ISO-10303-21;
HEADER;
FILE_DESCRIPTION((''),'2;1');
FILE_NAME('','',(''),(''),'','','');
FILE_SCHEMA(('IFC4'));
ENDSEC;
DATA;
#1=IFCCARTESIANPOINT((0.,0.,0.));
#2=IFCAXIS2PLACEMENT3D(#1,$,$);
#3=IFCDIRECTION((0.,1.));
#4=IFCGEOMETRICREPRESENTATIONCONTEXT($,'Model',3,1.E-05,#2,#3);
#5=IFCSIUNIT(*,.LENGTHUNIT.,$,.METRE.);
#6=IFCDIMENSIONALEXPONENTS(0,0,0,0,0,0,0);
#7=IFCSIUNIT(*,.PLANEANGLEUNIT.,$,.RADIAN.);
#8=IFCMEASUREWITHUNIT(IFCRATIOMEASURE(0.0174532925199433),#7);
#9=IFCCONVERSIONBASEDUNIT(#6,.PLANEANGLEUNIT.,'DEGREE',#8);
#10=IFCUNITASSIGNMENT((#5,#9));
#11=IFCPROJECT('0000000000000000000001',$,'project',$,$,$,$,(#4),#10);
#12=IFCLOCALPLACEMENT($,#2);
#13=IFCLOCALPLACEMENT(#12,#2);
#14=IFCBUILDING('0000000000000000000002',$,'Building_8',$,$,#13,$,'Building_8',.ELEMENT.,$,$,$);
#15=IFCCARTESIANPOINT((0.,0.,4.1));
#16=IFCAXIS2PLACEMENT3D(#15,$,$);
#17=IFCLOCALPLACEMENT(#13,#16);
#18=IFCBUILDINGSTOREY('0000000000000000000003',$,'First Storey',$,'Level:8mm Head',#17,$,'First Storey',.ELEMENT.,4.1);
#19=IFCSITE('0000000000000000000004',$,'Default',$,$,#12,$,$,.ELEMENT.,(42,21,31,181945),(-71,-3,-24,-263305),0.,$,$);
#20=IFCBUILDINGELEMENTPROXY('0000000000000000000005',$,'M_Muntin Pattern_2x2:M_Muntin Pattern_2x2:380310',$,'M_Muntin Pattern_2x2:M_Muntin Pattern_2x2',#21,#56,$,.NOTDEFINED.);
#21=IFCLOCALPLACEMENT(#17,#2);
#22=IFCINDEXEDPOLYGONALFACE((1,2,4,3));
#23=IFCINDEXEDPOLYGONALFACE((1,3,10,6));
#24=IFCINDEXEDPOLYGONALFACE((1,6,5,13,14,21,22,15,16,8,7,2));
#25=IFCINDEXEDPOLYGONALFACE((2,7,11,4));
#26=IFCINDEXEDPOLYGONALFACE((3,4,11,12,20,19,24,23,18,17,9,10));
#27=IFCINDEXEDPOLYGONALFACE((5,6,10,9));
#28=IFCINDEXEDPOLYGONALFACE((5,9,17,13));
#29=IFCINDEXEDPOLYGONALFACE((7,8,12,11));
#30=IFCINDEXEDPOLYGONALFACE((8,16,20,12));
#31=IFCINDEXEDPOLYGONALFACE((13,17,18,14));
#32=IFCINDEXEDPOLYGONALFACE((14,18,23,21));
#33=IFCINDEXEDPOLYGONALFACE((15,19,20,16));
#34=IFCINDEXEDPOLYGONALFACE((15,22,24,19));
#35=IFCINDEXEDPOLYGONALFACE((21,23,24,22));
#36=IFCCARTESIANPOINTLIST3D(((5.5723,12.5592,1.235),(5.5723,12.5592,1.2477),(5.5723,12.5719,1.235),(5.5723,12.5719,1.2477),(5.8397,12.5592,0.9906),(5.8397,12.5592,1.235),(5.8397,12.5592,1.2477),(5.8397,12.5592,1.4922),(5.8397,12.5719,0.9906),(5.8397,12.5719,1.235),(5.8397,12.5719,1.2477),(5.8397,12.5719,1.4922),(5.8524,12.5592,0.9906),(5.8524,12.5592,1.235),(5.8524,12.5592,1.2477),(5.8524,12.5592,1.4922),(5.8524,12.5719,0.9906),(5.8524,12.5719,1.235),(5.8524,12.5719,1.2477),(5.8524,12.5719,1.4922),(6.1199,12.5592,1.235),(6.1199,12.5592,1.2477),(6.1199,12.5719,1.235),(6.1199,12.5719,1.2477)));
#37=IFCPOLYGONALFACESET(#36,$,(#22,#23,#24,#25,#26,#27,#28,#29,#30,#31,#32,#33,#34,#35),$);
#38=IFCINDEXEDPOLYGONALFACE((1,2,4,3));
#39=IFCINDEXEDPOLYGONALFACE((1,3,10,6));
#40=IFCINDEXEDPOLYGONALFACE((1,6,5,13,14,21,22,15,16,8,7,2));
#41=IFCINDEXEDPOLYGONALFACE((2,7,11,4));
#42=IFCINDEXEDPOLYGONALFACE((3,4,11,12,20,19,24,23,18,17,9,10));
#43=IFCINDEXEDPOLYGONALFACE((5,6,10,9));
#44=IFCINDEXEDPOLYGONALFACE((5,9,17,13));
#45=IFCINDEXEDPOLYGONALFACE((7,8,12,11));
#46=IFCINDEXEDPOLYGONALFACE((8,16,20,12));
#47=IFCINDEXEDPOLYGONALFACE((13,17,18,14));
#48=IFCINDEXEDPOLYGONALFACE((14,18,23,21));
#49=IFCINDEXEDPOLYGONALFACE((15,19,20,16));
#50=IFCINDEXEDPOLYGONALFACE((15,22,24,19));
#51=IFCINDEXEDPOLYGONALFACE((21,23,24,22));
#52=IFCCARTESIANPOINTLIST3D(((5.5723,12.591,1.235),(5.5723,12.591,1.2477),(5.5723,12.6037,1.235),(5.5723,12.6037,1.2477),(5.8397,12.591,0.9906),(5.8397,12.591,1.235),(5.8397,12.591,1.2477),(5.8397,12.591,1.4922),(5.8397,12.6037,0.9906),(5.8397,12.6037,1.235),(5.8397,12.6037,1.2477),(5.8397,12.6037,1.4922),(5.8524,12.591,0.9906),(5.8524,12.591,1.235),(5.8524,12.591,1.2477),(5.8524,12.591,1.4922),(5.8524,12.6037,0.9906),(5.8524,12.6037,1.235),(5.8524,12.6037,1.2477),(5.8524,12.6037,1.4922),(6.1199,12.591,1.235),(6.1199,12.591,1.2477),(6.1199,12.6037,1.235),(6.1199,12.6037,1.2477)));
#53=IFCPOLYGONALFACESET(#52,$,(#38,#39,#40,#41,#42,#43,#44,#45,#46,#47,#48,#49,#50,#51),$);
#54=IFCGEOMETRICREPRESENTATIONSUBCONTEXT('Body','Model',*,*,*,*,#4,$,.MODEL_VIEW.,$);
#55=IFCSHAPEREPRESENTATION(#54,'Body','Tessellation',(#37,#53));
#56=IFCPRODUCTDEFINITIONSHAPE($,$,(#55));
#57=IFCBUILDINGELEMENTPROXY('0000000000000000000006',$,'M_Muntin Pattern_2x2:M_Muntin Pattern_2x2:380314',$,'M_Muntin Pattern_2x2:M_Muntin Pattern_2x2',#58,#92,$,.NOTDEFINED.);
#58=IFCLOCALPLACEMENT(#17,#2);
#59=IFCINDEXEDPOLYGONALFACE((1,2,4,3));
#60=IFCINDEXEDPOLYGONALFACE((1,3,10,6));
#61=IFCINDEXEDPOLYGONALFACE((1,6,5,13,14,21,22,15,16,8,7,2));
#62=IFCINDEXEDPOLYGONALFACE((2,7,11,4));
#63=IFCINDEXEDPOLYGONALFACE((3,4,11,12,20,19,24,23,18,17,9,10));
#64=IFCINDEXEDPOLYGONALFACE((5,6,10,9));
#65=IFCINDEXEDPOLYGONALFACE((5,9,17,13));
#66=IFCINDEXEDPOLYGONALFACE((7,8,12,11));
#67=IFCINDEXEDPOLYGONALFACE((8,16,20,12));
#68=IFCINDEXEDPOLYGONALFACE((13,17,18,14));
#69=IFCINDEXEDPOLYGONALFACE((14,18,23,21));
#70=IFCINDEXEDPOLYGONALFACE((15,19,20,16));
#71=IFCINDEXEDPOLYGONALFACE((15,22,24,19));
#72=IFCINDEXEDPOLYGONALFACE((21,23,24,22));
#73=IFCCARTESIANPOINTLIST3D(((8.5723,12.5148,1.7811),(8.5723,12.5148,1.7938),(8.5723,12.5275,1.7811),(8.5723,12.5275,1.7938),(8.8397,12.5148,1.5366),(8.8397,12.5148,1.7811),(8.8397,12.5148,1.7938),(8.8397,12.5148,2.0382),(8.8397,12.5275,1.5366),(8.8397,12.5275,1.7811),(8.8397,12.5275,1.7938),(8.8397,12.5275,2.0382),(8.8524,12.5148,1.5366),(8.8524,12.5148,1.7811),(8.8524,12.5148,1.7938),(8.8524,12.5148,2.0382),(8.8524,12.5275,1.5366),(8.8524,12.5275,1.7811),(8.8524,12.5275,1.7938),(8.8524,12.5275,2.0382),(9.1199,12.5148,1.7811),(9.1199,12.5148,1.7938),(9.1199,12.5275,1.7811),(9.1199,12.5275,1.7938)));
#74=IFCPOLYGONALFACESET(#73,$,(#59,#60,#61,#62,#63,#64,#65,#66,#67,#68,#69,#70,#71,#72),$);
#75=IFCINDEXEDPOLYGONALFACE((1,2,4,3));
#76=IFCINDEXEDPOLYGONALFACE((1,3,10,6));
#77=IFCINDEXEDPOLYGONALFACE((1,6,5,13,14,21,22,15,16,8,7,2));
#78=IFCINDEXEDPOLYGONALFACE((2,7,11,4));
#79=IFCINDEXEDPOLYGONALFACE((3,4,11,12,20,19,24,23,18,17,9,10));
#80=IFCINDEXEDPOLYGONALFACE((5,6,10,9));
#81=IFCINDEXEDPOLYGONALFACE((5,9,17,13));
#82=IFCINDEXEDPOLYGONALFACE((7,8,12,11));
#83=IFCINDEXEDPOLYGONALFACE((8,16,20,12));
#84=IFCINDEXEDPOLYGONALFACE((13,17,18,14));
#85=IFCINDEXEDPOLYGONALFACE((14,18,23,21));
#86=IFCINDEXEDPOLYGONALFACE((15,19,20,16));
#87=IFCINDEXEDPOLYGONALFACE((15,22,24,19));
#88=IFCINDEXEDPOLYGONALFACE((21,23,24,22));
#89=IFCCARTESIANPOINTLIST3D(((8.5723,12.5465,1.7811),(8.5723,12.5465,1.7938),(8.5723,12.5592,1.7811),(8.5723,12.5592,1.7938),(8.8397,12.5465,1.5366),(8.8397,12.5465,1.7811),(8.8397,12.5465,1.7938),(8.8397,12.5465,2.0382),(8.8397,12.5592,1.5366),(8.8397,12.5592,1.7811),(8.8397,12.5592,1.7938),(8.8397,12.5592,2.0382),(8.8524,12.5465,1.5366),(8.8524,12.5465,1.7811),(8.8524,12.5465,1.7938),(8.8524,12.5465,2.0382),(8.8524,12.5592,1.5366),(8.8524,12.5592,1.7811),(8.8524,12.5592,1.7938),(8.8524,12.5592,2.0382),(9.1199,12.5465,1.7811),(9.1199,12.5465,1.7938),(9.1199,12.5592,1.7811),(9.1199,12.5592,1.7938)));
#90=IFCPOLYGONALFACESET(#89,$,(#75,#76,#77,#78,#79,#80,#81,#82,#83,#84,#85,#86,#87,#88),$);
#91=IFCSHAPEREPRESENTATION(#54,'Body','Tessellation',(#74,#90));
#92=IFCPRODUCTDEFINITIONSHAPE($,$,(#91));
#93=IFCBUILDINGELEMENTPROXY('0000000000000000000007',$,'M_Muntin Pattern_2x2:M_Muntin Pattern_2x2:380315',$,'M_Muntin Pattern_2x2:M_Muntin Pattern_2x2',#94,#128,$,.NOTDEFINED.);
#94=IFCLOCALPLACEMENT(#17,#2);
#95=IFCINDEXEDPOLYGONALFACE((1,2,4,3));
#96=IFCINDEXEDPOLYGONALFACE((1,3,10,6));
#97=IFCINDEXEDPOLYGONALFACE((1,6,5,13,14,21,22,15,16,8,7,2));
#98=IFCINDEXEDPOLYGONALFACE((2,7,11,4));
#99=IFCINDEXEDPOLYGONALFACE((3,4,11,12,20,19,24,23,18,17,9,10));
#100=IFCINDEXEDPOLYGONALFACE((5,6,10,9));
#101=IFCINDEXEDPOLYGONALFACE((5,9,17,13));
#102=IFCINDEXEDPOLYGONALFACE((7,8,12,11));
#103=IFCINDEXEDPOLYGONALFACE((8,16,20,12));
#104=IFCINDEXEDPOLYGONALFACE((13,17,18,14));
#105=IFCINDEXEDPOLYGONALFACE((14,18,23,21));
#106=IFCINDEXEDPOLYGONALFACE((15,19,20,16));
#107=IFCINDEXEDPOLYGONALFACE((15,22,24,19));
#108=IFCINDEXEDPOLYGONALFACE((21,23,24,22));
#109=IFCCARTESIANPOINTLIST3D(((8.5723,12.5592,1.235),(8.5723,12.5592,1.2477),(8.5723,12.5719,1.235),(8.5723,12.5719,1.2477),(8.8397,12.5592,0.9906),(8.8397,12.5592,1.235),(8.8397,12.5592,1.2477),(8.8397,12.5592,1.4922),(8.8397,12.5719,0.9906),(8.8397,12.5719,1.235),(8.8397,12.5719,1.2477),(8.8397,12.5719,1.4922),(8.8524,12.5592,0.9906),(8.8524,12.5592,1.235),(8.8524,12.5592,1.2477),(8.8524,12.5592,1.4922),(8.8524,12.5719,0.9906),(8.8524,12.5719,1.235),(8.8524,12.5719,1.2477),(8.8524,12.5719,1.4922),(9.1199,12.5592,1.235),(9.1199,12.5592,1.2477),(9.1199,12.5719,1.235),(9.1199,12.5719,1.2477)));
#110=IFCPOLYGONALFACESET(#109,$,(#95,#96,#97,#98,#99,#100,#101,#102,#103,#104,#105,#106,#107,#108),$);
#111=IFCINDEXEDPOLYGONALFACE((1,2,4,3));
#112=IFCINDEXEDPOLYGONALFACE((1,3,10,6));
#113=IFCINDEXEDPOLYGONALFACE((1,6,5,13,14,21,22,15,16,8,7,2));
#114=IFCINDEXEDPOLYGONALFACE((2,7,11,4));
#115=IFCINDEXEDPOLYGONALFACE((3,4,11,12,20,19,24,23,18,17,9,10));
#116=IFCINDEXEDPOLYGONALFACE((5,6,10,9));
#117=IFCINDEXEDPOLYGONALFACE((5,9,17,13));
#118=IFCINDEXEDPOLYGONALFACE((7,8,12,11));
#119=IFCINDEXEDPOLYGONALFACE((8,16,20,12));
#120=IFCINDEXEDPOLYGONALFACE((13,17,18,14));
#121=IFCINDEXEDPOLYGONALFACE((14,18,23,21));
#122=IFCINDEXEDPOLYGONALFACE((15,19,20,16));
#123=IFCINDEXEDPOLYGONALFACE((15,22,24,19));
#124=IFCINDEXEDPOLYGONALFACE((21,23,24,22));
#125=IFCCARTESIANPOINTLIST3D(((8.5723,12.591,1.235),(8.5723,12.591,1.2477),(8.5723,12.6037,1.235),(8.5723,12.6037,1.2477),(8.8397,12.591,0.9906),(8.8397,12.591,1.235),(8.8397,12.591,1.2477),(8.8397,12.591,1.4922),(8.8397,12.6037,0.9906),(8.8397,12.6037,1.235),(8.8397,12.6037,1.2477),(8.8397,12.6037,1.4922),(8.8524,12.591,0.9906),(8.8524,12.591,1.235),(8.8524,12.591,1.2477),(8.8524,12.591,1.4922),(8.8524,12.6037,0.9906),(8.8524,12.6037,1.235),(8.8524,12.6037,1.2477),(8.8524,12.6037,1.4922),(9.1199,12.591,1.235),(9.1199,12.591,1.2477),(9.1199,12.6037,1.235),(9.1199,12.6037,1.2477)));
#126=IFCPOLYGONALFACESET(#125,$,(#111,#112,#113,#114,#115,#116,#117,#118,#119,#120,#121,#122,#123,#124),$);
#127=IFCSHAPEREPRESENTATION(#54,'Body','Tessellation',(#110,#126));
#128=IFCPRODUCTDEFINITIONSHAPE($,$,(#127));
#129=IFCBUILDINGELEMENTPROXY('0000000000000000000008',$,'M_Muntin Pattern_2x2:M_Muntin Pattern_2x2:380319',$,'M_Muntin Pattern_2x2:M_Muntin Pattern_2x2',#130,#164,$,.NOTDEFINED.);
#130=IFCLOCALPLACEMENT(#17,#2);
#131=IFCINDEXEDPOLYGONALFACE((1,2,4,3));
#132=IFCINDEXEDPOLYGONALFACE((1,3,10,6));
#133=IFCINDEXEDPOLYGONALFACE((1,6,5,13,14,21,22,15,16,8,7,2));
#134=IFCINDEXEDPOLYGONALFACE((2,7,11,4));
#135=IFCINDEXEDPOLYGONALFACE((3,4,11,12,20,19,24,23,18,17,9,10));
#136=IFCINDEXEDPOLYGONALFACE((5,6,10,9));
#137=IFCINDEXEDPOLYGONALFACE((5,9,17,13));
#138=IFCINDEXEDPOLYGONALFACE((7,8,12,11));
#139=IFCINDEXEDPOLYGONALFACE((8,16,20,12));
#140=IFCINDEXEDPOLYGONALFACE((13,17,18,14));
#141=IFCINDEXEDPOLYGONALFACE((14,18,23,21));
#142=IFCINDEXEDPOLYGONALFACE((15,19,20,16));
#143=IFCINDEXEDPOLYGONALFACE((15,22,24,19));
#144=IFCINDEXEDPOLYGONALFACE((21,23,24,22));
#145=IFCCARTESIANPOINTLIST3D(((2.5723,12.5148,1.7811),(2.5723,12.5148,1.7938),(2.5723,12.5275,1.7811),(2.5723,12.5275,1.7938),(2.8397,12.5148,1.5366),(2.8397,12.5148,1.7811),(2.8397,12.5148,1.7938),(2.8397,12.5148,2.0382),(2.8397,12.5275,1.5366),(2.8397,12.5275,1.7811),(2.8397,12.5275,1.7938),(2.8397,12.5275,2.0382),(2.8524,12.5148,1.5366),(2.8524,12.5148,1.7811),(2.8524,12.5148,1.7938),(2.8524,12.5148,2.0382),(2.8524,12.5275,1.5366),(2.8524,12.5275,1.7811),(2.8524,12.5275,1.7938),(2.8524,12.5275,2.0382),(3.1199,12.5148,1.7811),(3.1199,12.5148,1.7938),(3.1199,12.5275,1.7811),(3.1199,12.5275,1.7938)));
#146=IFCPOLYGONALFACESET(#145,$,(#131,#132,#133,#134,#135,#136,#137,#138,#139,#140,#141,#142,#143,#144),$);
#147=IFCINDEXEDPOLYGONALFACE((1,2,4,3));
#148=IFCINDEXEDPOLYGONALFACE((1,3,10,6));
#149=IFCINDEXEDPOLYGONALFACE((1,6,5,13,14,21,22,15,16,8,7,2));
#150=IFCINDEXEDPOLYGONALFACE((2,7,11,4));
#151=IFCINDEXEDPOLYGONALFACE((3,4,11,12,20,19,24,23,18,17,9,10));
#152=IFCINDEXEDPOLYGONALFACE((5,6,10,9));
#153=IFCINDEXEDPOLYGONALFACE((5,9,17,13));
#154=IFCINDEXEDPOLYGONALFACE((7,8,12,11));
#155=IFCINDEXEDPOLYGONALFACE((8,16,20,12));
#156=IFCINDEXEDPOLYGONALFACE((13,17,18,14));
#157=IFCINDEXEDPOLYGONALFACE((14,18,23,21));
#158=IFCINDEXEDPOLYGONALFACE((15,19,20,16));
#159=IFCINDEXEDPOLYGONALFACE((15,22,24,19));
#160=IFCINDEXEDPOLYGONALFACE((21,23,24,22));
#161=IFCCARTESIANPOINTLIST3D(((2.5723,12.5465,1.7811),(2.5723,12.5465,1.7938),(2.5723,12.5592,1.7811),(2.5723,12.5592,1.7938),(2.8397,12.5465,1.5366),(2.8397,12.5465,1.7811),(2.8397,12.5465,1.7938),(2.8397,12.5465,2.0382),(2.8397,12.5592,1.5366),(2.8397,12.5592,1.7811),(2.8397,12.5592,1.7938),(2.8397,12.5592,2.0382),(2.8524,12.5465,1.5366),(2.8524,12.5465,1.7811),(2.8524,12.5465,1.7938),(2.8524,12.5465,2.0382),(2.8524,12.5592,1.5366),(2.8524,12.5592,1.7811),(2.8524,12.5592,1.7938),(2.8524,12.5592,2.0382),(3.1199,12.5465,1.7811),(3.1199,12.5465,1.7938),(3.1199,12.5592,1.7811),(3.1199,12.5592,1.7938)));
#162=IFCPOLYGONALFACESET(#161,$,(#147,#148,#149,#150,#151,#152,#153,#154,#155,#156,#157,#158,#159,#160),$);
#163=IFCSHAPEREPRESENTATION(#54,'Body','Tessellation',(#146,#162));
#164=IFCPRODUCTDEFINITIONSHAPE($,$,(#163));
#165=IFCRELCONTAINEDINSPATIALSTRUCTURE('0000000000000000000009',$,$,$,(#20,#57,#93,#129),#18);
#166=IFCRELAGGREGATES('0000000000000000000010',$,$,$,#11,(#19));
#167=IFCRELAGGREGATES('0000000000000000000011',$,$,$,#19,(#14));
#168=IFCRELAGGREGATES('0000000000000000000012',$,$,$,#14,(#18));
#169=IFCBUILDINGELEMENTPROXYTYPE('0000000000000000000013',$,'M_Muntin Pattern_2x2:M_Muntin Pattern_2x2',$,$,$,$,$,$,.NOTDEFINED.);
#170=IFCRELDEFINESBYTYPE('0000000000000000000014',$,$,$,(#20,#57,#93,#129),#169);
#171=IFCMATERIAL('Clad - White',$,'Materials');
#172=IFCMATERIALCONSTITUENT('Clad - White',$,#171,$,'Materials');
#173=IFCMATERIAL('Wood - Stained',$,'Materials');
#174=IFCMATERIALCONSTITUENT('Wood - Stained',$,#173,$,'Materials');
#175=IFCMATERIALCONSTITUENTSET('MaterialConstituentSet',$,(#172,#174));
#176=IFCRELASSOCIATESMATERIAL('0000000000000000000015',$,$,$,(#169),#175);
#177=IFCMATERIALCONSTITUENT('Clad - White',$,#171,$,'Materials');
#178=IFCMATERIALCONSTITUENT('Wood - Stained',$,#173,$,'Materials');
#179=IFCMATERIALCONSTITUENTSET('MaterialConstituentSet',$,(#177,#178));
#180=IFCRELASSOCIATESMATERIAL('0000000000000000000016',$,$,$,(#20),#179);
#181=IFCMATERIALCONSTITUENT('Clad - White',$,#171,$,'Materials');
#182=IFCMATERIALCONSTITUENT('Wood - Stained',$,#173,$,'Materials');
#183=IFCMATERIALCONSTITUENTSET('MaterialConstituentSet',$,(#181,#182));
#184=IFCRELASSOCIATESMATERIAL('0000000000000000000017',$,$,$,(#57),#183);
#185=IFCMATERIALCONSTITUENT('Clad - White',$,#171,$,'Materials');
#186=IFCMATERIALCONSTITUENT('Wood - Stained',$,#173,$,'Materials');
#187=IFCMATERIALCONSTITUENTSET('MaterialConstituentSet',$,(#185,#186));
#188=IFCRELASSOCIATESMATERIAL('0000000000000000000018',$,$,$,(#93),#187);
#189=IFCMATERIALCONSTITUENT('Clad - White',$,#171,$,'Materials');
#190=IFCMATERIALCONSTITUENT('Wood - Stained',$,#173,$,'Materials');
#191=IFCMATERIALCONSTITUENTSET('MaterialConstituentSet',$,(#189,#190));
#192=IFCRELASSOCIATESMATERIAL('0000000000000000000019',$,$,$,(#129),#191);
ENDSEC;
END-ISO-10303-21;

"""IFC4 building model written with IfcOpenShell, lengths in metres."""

from ifc_helpers import new_model, entity, si_unit, converted_unit, direction, frame, origin, place, context, subcontext, project, spatial, indexed_curve, outline, extrude, source, transform, mapped, material, constituent, constituent_set, type_object, type_shapes, element, save


model = new_model("IFC4")

# Units and contexts
model_context = context("Model", 3, precision=1e-05, world=origin(), true_north=direction((0.0, 1.0)))
body_context = subcontext(model_context, "Body", "Model", "MODEL_VIEW")
ifc_project = project(units=[si_unit("LENGTHUNIT", "METRE"), converted_unit("PLANEANGLEUNIT", "DEGREE", entity("IfcRatioMeasure", 0.0174532925199433), si_unit("PLANEANGLEUNIT", "RADIAN"), dimensions=[0, 0, 0, 0, 0, 0, 0])], contexts=[model_context])

# Site, building, storey
site_placement = place(None, origin())
site = spatial("IfcSite", under=ifc_project, at=site_placement, Name="Default", CompositionType="ELEMENT", RefLatitude=(42, 21, 31, 181945), RefLongitude=(-71, -3, -24, -263305), RefElevation=0.0)
building_placement = place(site_placement, origin())
building = spatial("IfcBuilding", under=site, at=building_placement, Name="Building_8", LongName="Building_8", CompositionType="ELEMENT")
storey_placement = place(building_placement, frame((0.0, 0.0, 4.1)))
storey = spatial("IfcBuildingStorey", under=building, at=storey_placement, Name="First Storey", ObjectType="Level:8mm Head", LongName="First Storey", CompositionType="ELEMENT", Elevation=4.1)

# Building element proxies
ifc_material_1 = material(Name="Clad - White", Category="Materials")
ifc_material_2 = material(Name="Wood - Stained", Category="Materials")
ifc_constituent_1 = constituent(ifc_material_1, Name="Clad - White", Category="Materials")
ifc_constituent_2 = constituent(ifc_material_2, Name="Wood - Stained", Category="Materials")
ifc_constituent_set_1 = constituent_set(constituents=[ifc_constituent_1, ifc_constituent_2], Name="MaterialConstituentSet")
building_element_proxy_type_1 = type_object("IfcBuildingElementProxyType", Name="M_Muntin Pattern_2x2:M_Muntin Pattern_2x2", PredefinedType="NOTDEFINED", material=ifc_constituent_set_1)
shared_shape_1 = source(origin(), body_context, "Body", "SweptSolid", [
    extrude(outline(indexed_curve([(0.0064, -0.0064), (0.2508, -0.0064), (0.2508, 0.0063), (0.0064, 0.0063), (0.0064, 0.2738), (-0.0063, 0.2738), (-0.0063, 0.0063), (-0.2508, 0.0063), (-0.2508, -0.0064), (-0.0063, -0.0064), (-0.0063, -0.2738), (0.0064, -0.2738), (0.0064, -0.0064)], self_intersect=False)), frame((0.0, -0.0222, 0.2508), z_axis=(0.0, 1.0, 0.0), x_axis=(0.0, 0.0, 1.0)), (0.0, 0.0, 1.0), 0.0127),
    extrude(outline(indexed_curve([(0.0064, -0.0064), (0.2508, -0.0064), (0.2508, 0.0063), (0.0064, 0.0063), (0.0064, 0.2738), (-0.0063, 0.2738), (-0.0063, 0.0063), (-0.2508, 0.0063), (-0.2508, -0.0064), (-0.0063, -0.0064), (-0.0063, -0.2738), (0.0064, -0.2738), (0.0064, -0.0064)], self_intersect=False)), frame((0.0, 0.0095, 0.2508), z_axis=(0.0, 1.0, 0.0), x_axis=(0.0, 0.0, 1.0)), (0.0, 0.0, 1.0), 0.0127),
])
type_shapes(building_element_proxy_type_1, [shared_shape_1])
ifc_constituent_3 = constituent(ifc_material_1, Name="Clad - White", Category="Materials")
ifc_constituent_4 = constituent(ifc_material_2, Name="Wood - Stained", Category="Materials")
ifc_constituent_set_2 = constituent_set(constituents=[ifc_constituent_3, ifc_constituent_4], Name="MaterialConstituentSet")
proxy_1_placement = place(storey_placement, frame((5.8461, 12.5814, 0.9906)))
element("IfcBuildingElementProxy", 1, at=proxy_1_placement, inside=storey, type_object=building_element_proxy_type_1, material=ifc_constituent_set_2, Name="M_Muntin Pattern_2x2:M_Muntin Pattern_2x2:380310", ObjectType="M_Muntin Pattern_2x2:M_Muntin Pattern_2x2", PredefinedType="NOTDEFINED", context=body_context, shape_type="MappedRepresentation", body=[
    mapped(shared_shape_1, transform((0.0, 0.0, 0.0), scale=1.0)),
])
ifc_constituent_5 = constituent(ifc_material_1, Name="Clad - White", Category="Materials")
ifc_constituent_6 = constituent(ifc_material_2, Name="Wood - Stained", Category="Materials")
ifc_constituent_set_3 = constituent_set(constituents=[ifc_constituent_5, ifc_constituent_6], Name="MaterialConstituentSet")
proxy_2_placement = place(storey_placement, frame((8.8461, 12.537, 1.5366)))
element("IfcBuildingElementProxy", 2, at=proxy_2_placement, inside=storey, type_object=building_element_proxy_type_1, material=ifc_constituent_set_3, Name="M_Muntin Pattern_2x2:M_Muntin Pattern_2x2:380314", ObjectType="M_Muntin Pattern_2x2:M_Muntin Pattern_2x2", PredefinedType="NOTDEFINED", context=body_context, shape_type="MappedRepresentation", body=[
    mapped(shared_shape_1, transform((0.0, 0.0, 0.0), scale=1.0)),
])
ifc_constituent_7 = constituent(ifc_material_1, Name="Clad - White", Category="Materials")
ifc_constituent_8 = constituent(ifc_material_2, Name="Wood - Stained", Category="Materials")
ifc_constituent_set_4 = constituent_set(constituents=[ifc_constituent_7, ifc_constituent_8], Name="MaterialConstituentSet")
proxy_3_placement = place(storey_placement, frame((8.8461, 12.5814, 0.9906)))
element("IfcBuildingElementProxy", 3, at=proxy_3_placement, inside=storey, type_object=building_element_proxy_type_1, material=ifc_constituent_set_4, Name="M_Muntin Pattern_2x2:M_Muntin Pattern_2x2:380315", ObjectType="M_Muntin Pattern_2x2:M_Muntin Pattern_2x2", PredefinedType="NOTDEFINED", context=body_context, shape_type="MappedRepresentation", body=[
    mapped(shared_shape_1, transform((0.0, 0.0, 0.0), scale=1.0)),
])
ifc_constituent_9 = constituent(ifc_material_1, Name="Clad - White", Category="Materials")
ifc_constituent_10 = constituent(ifc_material_2, Name="Wood - Stained", Category="Materials")
ifc_constituent_set_5 = constituent_set(constituents=[ifc_constituent_9, ifc_constituent_10], Name="MaterialConstituentSet")
proxy_4_placement = place(storey_placement, frame((2.8461, 12.537, 1.5366)))
element("IfcBuildingElementProxy", 4, at=proxy_4_placement, inside=storey, type_object=building_element_proxy_type_1, material=ifc_constituent_set_5, Name="M_Muntin Pattern_2x2:M_Muntin Pattern_2x2:380319", ObjectType="M_Muntin Pattern_2x2:M_Muntin Pattern_2x2", PredefinedType="NOTDEFINED", context=body_context, shape_type="MappedRepresentation", body=[
    mapped(shared_shape_1, transform((0.0, 0.0, 0.0), scale=1.0)),
])

save(model, "model.ifc")
